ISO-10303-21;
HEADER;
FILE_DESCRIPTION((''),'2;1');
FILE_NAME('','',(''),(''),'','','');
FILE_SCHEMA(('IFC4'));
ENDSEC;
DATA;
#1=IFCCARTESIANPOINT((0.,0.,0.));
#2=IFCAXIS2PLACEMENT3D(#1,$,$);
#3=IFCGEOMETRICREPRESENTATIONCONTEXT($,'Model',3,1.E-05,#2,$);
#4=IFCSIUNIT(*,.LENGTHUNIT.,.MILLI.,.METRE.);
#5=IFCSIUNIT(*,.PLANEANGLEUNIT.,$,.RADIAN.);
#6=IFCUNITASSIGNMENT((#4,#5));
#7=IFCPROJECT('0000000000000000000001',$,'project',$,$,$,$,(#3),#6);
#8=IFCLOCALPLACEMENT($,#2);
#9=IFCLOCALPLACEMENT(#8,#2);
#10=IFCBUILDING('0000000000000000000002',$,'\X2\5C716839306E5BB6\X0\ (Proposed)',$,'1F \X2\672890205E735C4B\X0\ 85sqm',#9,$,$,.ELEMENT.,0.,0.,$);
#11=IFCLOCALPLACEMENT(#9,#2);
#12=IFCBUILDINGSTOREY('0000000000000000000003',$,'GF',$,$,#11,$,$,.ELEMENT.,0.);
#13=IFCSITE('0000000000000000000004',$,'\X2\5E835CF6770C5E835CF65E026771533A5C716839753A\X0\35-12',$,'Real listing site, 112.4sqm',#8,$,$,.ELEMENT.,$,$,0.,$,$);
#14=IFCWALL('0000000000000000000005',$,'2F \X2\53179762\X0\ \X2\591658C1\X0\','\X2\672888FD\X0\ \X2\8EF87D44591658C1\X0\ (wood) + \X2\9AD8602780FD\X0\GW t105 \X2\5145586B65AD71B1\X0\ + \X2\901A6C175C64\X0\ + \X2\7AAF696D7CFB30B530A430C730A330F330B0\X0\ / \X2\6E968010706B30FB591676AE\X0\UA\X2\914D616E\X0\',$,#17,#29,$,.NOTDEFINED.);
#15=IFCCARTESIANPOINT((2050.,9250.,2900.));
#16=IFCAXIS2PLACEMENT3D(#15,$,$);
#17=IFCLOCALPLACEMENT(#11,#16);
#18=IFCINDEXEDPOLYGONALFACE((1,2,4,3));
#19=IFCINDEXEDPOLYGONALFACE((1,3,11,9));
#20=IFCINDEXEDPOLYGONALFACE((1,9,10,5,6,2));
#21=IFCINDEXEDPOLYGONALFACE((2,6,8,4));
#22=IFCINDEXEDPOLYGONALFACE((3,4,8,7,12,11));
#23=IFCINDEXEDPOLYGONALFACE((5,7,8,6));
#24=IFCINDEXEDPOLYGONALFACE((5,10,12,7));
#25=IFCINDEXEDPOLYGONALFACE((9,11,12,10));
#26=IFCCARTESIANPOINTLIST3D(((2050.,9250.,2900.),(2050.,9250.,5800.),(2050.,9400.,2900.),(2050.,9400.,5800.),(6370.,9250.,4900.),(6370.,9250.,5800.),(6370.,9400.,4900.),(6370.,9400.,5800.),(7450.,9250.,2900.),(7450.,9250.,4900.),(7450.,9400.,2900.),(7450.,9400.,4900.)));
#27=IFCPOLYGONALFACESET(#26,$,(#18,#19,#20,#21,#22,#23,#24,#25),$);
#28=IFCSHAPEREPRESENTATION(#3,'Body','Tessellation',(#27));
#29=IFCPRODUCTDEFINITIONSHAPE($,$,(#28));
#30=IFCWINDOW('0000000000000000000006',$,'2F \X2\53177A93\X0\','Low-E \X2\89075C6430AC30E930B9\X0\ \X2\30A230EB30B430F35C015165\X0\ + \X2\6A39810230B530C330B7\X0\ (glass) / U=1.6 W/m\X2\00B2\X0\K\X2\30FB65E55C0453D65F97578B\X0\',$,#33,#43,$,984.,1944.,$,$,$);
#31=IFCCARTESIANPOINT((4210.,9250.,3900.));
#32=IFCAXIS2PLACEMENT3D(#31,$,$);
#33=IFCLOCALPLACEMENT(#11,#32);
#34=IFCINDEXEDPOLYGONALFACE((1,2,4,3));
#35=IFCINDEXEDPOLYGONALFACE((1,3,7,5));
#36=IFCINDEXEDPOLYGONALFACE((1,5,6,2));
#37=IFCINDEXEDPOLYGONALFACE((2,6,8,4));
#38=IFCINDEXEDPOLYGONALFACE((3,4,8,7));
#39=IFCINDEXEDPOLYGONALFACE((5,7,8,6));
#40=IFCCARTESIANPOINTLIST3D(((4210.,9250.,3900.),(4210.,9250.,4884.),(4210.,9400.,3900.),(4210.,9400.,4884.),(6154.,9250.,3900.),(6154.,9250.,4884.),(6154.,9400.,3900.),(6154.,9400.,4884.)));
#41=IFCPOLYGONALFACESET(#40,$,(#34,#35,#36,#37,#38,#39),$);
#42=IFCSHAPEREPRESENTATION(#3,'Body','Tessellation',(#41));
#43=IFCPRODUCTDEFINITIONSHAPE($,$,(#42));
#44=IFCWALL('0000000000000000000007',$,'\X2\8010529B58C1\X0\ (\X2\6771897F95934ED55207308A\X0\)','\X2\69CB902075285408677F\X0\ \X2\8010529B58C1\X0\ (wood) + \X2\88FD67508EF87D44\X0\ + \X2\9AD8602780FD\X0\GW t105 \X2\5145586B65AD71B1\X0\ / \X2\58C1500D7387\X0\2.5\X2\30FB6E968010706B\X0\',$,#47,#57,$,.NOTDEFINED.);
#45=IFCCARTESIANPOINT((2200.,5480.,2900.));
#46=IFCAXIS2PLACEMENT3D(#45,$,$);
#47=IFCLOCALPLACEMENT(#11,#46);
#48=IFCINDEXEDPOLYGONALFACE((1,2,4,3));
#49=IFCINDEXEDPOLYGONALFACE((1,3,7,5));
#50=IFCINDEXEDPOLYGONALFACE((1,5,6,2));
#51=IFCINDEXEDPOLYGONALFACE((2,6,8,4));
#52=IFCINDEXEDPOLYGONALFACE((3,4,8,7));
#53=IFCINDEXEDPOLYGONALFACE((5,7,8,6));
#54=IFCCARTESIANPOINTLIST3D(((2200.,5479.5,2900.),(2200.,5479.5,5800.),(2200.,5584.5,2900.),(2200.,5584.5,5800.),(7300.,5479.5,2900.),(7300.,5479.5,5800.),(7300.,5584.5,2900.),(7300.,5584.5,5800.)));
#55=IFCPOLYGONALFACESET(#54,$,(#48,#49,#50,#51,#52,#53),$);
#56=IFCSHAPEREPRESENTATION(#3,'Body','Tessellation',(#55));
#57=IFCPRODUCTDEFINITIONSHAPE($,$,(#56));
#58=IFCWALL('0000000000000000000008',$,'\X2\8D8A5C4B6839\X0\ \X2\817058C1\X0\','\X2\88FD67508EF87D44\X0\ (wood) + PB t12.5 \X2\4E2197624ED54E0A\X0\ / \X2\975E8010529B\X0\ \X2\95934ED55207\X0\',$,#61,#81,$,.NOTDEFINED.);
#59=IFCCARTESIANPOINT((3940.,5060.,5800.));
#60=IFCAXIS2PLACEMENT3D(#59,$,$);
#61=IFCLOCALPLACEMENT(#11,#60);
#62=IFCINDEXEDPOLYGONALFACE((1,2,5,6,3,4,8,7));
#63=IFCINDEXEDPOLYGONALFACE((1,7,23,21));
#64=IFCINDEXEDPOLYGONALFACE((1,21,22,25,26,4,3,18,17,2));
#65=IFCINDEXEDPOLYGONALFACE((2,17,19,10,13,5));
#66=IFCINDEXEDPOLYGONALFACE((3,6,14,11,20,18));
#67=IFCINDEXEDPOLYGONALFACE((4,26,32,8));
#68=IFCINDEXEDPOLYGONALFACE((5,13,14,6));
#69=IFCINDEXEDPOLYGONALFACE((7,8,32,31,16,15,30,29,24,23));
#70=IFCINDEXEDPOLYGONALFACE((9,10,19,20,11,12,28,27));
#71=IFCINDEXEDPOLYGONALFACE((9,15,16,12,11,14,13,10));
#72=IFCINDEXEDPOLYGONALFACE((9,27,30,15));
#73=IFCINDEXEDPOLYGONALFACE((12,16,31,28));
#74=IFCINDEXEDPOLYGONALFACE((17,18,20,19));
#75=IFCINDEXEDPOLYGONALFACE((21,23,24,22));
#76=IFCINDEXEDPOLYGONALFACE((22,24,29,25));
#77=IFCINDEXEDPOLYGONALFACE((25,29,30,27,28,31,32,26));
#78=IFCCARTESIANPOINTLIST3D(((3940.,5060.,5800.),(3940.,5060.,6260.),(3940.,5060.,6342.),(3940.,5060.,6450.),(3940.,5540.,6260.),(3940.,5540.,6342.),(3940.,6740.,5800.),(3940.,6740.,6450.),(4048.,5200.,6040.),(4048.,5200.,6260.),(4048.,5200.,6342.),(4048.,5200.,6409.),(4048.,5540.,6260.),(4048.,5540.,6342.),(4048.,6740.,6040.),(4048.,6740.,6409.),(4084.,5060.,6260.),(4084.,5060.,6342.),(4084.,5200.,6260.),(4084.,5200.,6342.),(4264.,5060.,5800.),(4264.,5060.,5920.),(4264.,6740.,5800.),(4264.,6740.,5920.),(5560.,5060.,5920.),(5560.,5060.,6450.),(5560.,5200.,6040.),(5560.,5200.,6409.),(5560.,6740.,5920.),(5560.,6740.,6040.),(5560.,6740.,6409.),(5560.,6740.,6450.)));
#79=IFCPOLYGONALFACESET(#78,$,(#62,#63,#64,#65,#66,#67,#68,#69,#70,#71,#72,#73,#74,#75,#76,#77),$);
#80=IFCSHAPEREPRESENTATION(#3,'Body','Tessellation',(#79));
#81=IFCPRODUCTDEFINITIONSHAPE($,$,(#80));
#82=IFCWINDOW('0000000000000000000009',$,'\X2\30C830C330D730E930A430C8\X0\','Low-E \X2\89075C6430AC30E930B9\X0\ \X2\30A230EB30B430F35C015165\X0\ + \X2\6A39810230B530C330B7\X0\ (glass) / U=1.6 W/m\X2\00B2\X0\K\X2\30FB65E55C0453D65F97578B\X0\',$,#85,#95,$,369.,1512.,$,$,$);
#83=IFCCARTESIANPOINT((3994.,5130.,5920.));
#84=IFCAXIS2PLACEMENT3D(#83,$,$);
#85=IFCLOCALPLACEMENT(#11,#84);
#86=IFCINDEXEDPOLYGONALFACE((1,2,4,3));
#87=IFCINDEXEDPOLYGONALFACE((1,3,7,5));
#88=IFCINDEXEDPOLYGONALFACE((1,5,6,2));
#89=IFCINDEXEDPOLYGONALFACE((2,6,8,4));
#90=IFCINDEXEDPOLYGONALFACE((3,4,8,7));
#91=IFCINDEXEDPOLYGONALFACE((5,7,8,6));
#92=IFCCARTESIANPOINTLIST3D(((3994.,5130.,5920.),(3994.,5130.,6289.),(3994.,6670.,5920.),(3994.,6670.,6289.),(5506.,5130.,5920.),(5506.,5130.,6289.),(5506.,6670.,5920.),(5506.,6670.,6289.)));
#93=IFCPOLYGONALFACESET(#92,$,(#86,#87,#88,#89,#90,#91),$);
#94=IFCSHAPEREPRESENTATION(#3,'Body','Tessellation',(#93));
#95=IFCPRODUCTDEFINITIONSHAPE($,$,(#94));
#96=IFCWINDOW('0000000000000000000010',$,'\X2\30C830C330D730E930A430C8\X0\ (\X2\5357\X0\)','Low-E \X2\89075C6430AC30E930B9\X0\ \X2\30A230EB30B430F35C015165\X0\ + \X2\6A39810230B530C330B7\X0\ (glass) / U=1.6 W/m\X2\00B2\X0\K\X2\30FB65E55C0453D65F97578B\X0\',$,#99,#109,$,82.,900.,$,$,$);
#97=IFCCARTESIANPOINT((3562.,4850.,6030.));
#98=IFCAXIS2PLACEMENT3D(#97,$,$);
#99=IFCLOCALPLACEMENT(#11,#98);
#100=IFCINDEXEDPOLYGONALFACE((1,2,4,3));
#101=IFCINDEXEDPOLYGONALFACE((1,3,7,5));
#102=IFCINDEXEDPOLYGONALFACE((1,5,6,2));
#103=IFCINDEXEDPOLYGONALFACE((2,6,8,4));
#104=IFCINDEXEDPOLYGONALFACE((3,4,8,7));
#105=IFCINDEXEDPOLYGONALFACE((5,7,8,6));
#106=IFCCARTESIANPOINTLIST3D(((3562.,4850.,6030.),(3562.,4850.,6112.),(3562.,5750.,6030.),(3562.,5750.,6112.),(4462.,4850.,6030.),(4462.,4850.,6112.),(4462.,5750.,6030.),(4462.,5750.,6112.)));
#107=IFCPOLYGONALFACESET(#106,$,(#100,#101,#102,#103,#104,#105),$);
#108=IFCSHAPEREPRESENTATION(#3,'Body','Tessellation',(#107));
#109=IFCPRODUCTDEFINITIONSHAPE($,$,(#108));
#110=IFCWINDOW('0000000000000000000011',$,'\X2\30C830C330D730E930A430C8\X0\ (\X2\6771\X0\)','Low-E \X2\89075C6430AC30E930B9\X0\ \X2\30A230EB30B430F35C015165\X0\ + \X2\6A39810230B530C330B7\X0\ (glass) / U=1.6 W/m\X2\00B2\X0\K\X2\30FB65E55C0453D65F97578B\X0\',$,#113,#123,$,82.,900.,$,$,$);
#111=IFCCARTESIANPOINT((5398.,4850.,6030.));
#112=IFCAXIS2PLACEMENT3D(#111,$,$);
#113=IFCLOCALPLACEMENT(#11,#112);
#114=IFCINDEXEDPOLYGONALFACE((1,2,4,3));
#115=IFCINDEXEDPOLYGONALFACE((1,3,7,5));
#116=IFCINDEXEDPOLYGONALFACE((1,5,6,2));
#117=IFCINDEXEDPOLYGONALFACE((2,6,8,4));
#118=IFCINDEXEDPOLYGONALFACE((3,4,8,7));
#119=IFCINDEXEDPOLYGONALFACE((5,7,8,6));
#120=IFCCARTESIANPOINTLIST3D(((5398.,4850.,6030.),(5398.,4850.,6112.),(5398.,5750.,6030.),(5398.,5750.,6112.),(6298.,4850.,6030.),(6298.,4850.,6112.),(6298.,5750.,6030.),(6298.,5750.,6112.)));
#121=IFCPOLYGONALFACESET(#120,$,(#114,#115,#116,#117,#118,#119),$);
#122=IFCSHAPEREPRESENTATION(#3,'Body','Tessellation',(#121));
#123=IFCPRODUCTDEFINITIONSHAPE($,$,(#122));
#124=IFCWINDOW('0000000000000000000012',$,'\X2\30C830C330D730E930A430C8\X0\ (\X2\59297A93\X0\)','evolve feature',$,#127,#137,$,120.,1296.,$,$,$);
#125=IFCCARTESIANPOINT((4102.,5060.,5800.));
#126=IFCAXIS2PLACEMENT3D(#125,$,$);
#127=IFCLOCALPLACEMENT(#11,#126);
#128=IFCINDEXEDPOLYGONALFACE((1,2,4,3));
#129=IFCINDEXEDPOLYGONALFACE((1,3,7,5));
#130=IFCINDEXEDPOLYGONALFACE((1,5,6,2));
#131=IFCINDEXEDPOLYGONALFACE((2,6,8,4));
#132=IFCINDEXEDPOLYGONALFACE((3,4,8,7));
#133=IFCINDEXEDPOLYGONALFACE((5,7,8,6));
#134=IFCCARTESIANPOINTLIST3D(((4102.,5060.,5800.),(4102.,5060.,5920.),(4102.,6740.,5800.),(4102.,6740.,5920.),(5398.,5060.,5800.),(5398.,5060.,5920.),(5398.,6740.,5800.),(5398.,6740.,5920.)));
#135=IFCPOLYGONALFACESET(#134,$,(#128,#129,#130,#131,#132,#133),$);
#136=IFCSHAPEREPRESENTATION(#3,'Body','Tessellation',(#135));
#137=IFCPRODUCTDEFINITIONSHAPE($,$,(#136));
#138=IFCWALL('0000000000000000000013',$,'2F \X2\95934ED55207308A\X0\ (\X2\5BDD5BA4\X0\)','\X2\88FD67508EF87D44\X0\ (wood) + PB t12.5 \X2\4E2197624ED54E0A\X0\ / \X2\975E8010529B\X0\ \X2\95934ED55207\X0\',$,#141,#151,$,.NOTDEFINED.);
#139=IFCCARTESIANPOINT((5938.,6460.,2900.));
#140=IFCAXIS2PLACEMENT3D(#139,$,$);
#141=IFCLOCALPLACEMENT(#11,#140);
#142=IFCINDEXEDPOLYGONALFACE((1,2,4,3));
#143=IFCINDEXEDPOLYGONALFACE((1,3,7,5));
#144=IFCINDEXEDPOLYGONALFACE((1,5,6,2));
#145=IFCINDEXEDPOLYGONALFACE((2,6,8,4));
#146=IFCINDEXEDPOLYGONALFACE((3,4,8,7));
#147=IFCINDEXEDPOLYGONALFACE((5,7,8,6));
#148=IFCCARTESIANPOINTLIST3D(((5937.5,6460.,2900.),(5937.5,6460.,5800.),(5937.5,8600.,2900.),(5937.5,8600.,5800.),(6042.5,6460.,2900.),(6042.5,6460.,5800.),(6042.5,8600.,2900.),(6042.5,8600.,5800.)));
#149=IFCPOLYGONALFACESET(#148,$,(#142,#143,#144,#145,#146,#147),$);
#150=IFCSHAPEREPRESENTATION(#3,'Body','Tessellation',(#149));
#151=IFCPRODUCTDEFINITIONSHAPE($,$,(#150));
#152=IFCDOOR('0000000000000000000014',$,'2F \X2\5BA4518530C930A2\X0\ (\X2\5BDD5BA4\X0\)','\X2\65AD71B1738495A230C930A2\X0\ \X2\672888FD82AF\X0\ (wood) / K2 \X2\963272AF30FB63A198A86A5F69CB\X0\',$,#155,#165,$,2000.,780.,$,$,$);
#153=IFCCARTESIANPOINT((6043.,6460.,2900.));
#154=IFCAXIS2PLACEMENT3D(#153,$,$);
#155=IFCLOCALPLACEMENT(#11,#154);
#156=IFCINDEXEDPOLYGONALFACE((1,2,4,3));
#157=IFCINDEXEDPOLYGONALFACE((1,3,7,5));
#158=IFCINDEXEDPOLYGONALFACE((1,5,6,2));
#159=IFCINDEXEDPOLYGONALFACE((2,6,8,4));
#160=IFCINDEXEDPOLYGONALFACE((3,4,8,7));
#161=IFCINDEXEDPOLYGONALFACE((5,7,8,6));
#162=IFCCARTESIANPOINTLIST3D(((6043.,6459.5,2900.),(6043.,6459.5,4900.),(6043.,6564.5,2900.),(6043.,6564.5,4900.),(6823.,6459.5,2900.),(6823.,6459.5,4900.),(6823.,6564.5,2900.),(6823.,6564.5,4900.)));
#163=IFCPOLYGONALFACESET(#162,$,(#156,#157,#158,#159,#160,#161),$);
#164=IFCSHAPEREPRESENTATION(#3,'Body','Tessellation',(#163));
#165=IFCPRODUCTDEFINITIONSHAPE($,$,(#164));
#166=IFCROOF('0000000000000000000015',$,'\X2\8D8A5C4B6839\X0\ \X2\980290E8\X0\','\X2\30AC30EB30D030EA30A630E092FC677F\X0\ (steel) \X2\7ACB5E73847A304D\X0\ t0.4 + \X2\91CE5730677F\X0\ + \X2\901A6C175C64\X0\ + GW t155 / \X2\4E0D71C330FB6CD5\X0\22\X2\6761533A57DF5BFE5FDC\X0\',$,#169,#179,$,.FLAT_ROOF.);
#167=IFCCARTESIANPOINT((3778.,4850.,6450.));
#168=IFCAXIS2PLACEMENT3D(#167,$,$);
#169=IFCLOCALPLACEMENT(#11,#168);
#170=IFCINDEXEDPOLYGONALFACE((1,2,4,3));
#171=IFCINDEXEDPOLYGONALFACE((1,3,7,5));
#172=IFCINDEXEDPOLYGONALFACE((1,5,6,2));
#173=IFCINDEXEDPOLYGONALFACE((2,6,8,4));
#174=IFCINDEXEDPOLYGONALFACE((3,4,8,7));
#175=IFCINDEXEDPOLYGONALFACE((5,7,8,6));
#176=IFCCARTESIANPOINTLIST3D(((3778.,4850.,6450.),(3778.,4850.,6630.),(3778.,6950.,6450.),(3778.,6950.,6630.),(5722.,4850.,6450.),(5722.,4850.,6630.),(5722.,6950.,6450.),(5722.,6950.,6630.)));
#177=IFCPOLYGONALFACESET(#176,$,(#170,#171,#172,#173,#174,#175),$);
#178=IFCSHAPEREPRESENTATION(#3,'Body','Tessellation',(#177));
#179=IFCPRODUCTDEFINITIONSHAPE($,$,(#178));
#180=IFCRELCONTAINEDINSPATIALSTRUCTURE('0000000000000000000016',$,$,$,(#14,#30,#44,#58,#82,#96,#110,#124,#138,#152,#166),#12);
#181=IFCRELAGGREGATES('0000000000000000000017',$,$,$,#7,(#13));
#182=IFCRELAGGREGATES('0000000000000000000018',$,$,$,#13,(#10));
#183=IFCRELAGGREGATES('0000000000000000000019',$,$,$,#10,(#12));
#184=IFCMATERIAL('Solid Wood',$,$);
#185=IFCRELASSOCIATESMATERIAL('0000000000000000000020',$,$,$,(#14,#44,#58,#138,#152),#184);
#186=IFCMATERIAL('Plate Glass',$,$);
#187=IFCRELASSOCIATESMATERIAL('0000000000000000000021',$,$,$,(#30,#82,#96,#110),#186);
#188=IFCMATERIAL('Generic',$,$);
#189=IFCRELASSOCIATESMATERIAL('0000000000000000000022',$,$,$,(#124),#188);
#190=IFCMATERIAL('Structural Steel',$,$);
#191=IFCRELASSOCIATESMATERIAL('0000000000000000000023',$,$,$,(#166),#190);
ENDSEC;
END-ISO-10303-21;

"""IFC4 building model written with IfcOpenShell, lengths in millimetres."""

from ifc_helpers import new_model, si_unit, frame, frame_2d, origin, place, context, project, spatial, rectangle, extrude, material, element, fill, save


model = new_model("IFC4")

# Units and contexts
model_context = context("Model", 3, precision=1e-05, world=origin())
ifc_project = project(units=[si_unit("LENGTHUNIT", "METRE", prefix="MILLI"), si_unit("PLANEANGLEUNIT", "RADIAN")], contexts=[model_context])

# Site, building, storey
site_placement = place(None, origin())
site = spatial("IfcSite", under=ifc_project, at=site_placement, Name="広島県広島市東区山根町35-12", ObjectType="Real listing site, 112.4sqm", CompositionType="ELEMENT", RefElevation=0.0)
building_placement = place(site_placement, origin())
building = spatial("IfcBuilding", under=site, at=building_placement, Name="山根の家 (Proposed)", ObjectType="1F 木造平屋 85sqm", CompositionType="ELEMENT", ElevationOfRefHeight=0.0, ElevationOfTerrain=0.0)
storey_placement = place(building_placement, origin())
storey = spatial("IfcBuildingStorey", under=building, at=storey_placement, Name="GF", CompositionType="ELEMENT", Elevation=0.0)

# Wall, opening, window
ifc_material_1 = material(Name="Solid Wood")
wall_1_placement = place(storey_placement, frame((2050.0, 9250.0, 2900.0)))
wall_1 = element("IfcWall", 1, at=wall_1_placement, inside=storey, material=ifc_material_1, Name="2F 北面 外壁", Description="木製 軸組外壁 (wood) + 高性能GW t105 充填断熱 + 通気層 + 窯業系サイディング / 準耐火・外皮UA配慮", PredefinedType="NOTDEFINED", context=model_context, shape_type="SweptSolid", body=[
    extrude(rectangle(XDim=5400.0, YDim=150.0, at=frame_2d((2700.0, 75.0))), frame((2050.0, 9250.0, 2900.0)), (0.0, 0.0, 1.0), 2900.0),
])
opening_1_placement = place(storey_placement, frame((4210.0, 9250.0, 3900.0)))
opening_1 = element("IfcOpeningElement", 2, at=opening_1_placement, cuts=wall_1, PredefinedType="NOTDEFINED", context=model_context, shape_type="SweptSolid", body=[
    extrude(rectangle(XDim=1944.0, YDim=150.0, at=frame_2d((972.0, 75.0))), frame((4210.0, 9250.0, 3900.0)), (0.0, 0.0, 1.0), 984.0),
])
ifc_material_2 = material(Name="Plate Glass")
window_1_placement = place(storey_placement, frame((4210.0, 9250.0, 3900.0)))
window_1 = element("IfcWindow", 3, at=window_1_placement, inside=storey, material=ifc_material_2, Name="2F 北窓", Description="Low-E 複層ガラス アルゴン封入 + 樹脂サッシ (glass) / U=1.6 W/m²K・日射取得型", OverallHeight=984.0, OverallWidth=1944.0, context=model_context, shape_type="SweptSolid", body=[
    extrude(rectangle(XDim=1944.0, YDim=150.0, at=frame_2d((972.0, 75.0))), frame((4210.0, 9250.0, 3900.0)), (0.0, 0.0, 1.0), 984.0),
])
fill(opening_1, window_1)

# Wall
wall_2_placement = place(storey_placement, frame((2200.0, 5480.0, 2900.0)))
element("IfcWall", 4, at=wall_2_placement, inside=storey, material=ifc_material_1, Name="耐力壁 (東西間仕切り)", Description="構造用合板 耐力壁 (wood) + 製材軸組 + 高性能GW t105 充填断熱 / 壁倍率2.5・準耐火", PredefinedType="NOTDEFINED", context=model_context, shape_type="SweptSolid", body=[
    extrude(rectangle(XDim=5100.0, YDim=105.0, at=frame_2d((2550.0, 52.0))), frame((2200.0, 5480.0, 2900.0)), (0.0, 0.0, 1.0), 2900.0),
])

# Wall, openings, windows
wall_3_placement = place(storey_placement, frame((3940.0, 5060.0, 5800.0)))
wall_3 = element("IfcWall", 5, at=wall_3_placement, inside=storey, material=ifc_material_1, Name="越屋根 腰壁", Description="製材軸組 (wood) + PB t12.5 両面仕上 / 非耐力 間仕切", PredefinedType="NOTDEFINED", context=model_context, shape_type="SweptSolid", body=[
    extrude(rectangle(XDim=1620.0, YDim=1680.0, at=frame_2d((810.0, 840.0))), frame((3940.0, 5060.0, 5800.0)), (0.0, 0.0, 1.0), 650.0),
])
opening_2_placement = place(storey_placement, frame((3994.0, 5130.0, 5920.0)))
opening_2 = element("IfcOpeningElement", 6, at=opening_2_placement, cuts=wall_3, PredefinedType="NOTDEFINED", context=model_context, shape_type="SweptSolid", body=[
    extrude(rectangle(XDim=1512.0, YDim=1540.0, at=frame_2d((756.0, 770.0))), frame((3994.0, 5130.0, 5920.0)), (0.0, 0.0, 1.0), 369.0),
])
opening_3_placement = place(storey_placement, frame((3562.0, 4850.0, 6030.0)))
opening_3 = element("IfcOpeningElement", 7, at=opening_3_placement, cuts=wall_3, PredefinedType="NOTDEFINED", context=model_context, shape_type="SweptSolid", body=[
    extrude(rectangle(XDim=900.0, YDim=900.0, at=frame_2d((450.0, 450.0))), frame((3562.0, 4850.0, 6030.0)), (0.0, 0.0, 1.0), 82.0),
])
opening_4_placement = place(storey_placement, frame((5398.0, 4850.0, 6030.0)))
opening_4 = element("IfcOpeningElement", 8, at=opening_4_placement, cuts=wall_3, PredefinedType="NOTDEFINED", context=model_context, shape_type="SweptSolid", body=[
    extrude(rectangle(XDim=900.0, YDim=900.0, at=frame_2d((450.0, 450.0))), frame((5398.0, 4850.0, 6030.0)), (0.0, 0.0, 1.0), 82.0),
])
opening_5_placement = place(storey_placement, frame((4102.0, 5060.0, 5800.0)))
opening_5 = element("IfcOpeningElement", 9, at=opening_5_placement, cuts=wall_3, PredefinedType="NOTDEFINED", context=model_context, shape_type="SweptSolid", body=[
    extrude(rectangle(XDim=1296.0, YDim=1680.0, at=frame_2d((648.0, 840.0))), frame((4102.0, 5060.0, 5800.0)), (0.0, 0.0, 1.0), 120.0),
])
window_2_placement = place(storey_placement, frame((3994.0, 5130.0, 5920.0)))
window_2 = element("IfcWindow", 10, at=window_2_placement, inside=storey, material=ifc_material_2, Name="トップライト", Description="Low-E 複層ガラス アルゴン封入 + 樹脂サッシ (glass) / U=1.6 W/m²K・日射取得型", OverallHeight=369.0, OverallWidth=1512.0, context=model_context, shape_type="SweptSolid", body=[
    extrude(rectangle(XDim=1512.0, YDim=1540.0, at=frame_2d((756.0, 770.0))), frame((3994.0, 5130.0, 5920.0)), (0.0, 0.0, 1.0), 369.0),
])
fill(opening_2, window_2)
window_3_placement = place(storey_placement, frame((3562.0, 4850.0, 6030.0)))
window_3 = element("IfcWindow", 11, at=window_3_placement, inside=storey, material=ifc_material_2, Name="トップライト (南)", Description="Low-E 複層ガラス アルゴン封入 + 樹脂サッシ (glass) / U=1.6 W/m²K・日射取得型", OverallHeight=82.0, OverallWidth=900.0, context=model_context, shape_type="SweptSolid", body=[
    extrude(rectangle(XDim=900.0, YDim=900.0, at=frame_2d((450.0, 450.0))), frame((3562.0, 4850.0, 6030.0)), (0.0, 0.0, 1.0), 82.0),
])
fill(opening_3, window_3)
window_4_placement = place(storey_placement, frame((5398.0, 4850.0, 6030.0)))
window_4 = element("IfcWindow", 12, at=window_4_placement, inside=storey, material=ifc_material_2, Name="トップライト (東)", Description="Low-E 複層ガラス アルゴン封入 + 樹脂サッシ (glass) / U=1.6 W/m²K・日射取得型", OverallHeight=82.0, OverallWidth=900.0, context=model_context, shape_type="SweptSolid", body=[
    extrude(rectangle(XDim=900.0, YDim=900.0, at=frame_2d((450.0, 450.0))), frame((5398.0, 4850.0, 6030.0)), (0.0, 0.0, 1.0), 82.0),
])
fill(opening_4, window_4)
ifc_material_3 = material(Name="Generic")
window_5_placement = place(storey_placement, frame((4102.0, 5060.0, 5800.0)))
window_5 = element("IfcWindow", 13, at=window_5_placement, inside=storey, material=ifc_material_3, Name="トップライト (天窓)", Description="evolve feature", OverallHeight=120.0, OverallWidth=1296.0, context=model_context, shape_type="SweptSolid", body=[
    extrude(rectangle(XDim=1296.0, YDim=1680.0, at=frame_2d((648.0, 840.0))), frame((4102.0, 5060.0, 5800.0)), (0.0, 0.0, 1.0), 120.0),
])
fill(opening_5, window_5)

# Wall
wall_4_placement = place(storey_placement, frame((5938.0, 6460.0, 2900.0)))
element("IfcWall", 14, at=wall_4_placement, inside=storey, material=ifc_material_1, Name="2F 間仕切り (寝室)", Description="製材軸組 (wood) + PB t12.5 両面仕上 / 非耐力 間仕切", PredefinedType="NOTDEFINED", context=model_context, shape_type="SweptSolid", body=[
    extrude(rectangle(XDim=105.0, YDim=2140.0, at=frame_2d((52.0, 1070.0))), frame((5938.0, 6460.0, 2900.0)), (0.0, 0.0, 1.0), 2900.0),
])

# Door
door_placement = place(storey_placement, frame((6043.0, 6460.0, 2900.0)))
element("IfcDoor", 15, at=door_placement, inside=storey, material=ifc_material_1, Name="2F 室内ドア (寝室)", Description="断熱玄関ドア 木製芯 (wood) / K2 防犯・採風機構", OverallHeight=2000.0, OverallWidth=780.0, context=model_context, shape_type="SweptSolid", body=[
    extrude(rectangle(XDim=780.0, YDim=105.0, at=frame_2d((390.0, 52.0))), frame((6043.0, 6460.0, 2900.0)), (0.0, 0.0, 1.0), 2000.0),
])

# Roof
ifc_material_4 = material(Name="Structural Steel")
roof_placement = place(storey_placement, frame((3778.0, 4850.0, 6450.0)))
element("IfcRoof", 16, at=roof_placement, inside=storey, material=ifc_material_4, Name="越屋根 頂部", Description="ガルバリウム鋼板 (steel) 立平葺き t0.4 + 野地板 + 通気層 + GW t155 / 不燃・法22条区域対応", PredefinedType="FLAT_ROOF", context=model_context, shape_type="SweptSolid", body=[
    extrude(rectangle(XDim=1944.0, YDim=2100.0, at=frame_2d((972.0, 1050.0))), frame((3778.0, 4850.0, 6450.0)), (0.0, 0.0, 1.0), 180.0),
])

save(model, "model.ifc")
